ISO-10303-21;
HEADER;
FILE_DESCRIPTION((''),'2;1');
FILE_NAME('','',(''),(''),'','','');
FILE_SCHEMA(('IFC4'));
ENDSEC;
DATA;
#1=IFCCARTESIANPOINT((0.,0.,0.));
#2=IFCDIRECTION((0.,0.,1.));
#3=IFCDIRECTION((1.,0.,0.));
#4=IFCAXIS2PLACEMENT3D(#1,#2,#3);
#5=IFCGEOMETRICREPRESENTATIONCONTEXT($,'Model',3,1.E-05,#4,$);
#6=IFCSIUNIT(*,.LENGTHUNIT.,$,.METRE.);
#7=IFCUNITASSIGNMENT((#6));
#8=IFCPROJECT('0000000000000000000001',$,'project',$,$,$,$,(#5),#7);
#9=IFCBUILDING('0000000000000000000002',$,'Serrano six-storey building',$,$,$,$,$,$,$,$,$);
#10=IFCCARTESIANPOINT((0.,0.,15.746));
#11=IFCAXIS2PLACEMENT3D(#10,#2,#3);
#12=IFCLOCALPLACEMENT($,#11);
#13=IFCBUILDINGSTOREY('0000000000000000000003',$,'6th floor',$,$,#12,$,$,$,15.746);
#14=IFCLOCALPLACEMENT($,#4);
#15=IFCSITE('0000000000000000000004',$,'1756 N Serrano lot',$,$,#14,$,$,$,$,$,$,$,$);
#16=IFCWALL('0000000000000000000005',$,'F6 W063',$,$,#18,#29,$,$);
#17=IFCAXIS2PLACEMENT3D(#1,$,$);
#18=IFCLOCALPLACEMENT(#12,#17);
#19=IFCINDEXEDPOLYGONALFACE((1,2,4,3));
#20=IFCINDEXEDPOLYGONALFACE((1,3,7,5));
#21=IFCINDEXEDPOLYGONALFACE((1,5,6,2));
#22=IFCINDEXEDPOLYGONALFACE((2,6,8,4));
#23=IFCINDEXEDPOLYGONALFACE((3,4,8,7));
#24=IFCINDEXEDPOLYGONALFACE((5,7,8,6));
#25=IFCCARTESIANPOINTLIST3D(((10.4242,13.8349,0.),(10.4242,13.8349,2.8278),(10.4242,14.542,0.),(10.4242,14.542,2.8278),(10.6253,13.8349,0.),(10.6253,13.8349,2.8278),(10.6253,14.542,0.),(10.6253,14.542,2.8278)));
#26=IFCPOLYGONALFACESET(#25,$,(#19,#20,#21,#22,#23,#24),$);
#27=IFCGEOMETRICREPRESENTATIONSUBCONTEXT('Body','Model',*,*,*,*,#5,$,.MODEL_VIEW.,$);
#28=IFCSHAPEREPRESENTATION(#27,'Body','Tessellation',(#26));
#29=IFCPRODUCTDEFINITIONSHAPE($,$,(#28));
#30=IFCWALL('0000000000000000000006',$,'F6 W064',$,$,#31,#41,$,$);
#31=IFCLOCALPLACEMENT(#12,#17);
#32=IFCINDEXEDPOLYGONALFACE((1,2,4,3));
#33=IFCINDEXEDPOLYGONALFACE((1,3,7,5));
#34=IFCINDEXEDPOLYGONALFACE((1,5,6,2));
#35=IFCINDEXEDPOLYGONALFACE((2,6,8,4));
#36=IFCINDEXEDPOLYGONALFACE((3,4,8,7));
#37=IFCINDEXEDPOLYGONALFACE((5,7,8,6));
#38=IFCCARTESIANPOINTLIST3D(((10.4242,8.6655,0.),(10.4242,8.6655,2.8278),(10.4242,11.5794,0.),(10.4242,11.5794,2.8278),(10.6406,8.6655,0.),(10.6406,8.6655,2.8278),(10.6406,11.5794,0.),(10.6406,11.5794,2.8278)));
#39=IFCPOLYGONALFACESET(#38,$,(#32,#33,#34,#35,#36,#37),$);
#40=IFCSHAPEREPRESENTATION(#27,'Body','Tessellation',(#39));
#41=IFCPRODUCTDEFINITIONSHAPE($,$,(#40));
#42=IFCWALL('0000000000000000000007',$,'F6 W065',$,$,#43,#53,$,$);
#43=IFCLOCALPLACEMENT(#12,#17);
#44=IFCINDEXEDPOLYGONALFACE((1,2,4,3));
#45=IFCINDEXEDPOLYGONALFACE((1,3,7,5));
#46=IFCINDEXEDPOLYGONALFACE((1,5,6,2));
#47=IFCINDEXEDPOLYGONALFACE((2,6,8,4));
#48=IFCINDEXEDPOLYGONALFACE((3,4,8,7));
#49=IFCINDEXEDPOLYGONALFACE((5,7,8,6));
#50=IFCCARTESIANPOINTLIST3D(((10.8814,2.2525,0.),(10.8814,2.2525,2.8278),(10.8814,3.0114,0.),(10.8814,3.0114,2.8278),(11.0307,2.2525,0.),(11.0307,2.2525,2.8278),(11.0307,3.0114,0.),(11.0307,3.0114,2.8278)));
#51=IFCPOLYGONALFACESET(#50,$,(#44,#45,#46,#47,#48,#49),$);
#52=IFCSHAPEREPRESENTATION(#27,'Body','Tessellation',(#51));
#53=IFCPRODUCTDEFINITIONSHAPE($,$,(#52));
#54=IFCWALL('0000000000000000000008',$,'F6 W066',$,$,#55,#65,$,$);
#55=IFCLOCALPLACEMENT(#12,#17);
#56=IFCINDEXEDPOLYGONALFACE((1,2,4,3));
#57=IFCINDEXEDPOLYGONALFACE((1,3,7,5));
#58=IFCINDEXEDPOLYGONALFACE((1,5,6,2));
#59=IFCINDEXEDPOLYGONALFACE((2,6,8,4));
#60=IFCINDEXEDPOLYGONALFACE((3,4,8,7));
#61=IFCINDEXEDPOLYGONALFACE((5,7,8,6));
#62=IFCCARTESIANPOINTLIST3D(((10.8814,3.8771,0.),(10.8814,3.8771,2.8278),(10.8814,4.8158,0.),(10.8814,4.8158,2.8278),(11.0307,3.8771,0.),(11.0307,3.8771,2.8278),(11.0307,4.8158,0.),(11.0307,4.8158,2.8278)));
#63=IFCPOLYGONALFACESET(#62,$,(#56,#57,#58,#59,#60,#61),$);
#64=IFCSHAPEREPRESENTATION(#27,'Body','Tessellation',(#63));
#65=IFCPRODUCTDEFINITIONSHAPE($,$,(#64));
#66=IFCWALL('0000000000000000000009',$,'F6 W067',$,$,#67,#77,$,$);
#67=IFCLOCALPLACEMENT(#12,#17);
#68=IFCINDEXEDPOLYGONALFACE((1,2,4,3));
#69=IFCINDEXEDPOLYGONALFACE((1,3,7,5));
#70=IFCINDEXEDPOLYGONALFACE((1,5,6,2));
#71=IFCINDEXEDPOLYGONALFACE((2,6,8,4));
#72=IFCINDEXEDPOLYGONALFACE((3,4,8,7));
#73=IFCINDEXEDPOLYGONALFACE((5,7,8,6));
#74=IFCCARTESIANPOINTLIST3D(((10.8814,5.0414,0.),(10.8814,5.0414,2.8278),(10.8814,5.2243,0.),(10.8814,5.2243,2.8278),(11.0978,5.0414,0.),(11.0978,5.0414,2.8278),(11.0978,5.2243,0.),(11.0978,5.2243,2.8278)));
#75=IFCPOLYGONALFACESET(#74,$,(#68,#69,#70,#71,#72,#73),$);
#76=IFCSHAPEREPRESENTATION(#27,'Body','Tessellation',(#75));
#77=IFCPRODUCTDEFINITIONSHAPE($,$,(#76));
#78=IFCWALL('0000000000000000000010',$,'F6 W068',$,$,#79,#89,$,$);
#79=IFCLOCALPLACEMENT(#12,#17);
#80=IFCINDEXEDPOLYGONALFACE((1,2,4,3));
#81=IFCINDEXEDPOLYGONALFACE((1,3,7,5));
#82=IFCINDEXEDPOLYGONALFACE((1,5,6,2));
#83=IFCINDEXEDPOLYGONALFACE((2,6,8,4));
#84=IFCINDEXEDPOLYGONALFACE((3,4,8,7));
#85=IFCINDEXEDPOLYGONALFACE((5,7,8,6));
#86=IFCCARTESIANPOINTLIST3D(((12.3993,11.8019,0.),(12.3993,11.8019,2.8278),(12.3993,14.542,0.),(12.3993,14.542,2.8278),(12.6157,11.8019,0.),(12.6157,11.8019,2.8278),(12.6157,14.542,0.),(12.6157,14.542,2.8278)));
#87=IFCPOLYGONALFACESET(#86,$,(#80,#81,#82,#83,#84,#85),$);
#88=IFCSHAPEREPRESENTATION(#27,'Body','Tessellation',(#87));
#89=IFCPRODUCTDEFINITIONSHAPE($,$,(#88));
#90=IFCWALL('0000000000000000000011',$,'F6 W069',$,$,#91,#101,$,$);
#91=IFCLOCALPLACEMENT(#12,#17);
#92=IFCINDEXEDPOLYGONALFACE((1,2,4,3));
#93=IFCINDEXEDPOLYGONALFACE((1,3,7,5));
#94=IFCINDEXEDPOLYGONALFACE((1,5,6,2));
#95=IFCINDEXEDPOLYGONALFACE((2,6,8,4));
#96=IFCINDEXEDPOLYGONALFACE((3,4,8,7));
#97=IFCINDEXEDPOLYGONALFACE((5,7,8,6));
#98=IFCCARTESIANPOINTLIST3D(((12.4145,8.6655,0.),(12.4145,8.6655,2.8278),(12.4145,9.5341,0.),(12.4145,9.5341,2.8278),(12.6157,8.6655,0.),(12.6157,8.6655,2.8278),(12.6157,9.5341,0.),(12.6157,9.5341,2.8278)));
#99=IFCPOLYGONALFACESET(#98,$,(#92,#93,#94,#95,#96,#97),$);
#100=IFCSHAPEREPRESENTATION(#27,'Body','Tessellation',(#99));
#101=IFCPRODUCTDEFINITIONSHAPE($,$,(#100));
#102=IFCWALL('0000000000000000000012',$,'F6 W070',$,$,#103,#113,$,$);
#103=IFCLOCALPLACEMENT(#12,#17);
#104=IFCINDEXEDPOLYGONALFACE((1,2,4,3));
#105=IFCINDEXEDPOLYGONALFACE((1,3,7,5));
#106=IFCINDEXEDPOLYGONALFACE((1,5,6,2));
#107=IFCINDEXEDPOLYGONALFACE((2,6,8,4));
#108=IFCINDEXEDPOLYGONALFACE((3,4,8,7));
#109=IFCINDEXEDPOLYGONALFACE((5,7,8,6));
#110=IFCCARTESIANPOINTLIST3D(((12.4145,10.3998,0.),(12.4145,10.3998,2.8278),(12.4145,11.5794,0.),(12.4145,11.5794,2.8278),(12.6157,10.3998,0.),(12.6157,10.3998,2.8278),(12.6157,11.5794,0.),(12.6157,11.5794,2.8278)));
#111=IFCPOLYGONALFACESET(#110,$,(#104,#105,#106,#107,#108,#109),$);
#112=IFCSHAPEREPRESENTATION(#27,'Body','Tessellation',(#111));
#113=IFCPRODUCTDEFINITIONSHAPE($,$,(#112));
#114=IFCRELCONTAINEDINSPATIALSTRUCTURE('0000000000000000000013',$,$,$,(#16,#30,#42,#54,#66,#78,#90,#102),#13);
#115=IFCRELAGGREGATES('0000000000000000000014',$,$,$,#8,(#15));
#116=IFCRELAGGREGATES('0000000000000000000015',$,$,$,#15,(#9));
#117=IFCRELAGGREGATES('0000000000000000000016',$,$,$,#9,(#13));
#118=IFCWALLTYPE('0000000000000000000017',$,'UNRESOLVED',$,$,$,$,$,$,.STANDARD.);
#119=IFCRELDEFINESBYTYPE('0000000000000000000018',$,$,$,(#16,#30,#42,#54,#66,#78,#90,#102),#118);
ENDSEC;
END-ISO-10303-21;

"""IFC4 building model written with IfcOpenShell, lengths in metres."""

from ifc_helpers import new_model, si_unit, frame, origin_with_axes, place, context, subcontext, project, spatial, polyline, outline, extrude, type_object, element, save


model = new_model("IFC4")

# Units and contexts
model_context = context("Model", 3, precision=1e-05, world=origin_with_axes())
body_context = subcontext(model_context, "Body", "Model", "MODEL_VIEW")
ifc_project = project(units=[si_unit("LENGTHUNIT", "METRE")], contexts=[model_context])

# Site, building, storey
site_placement = place(None, origin_with_axes())
site = spatial("IfcSite", under=ifc_project, at=site_placement, Name="1756 N Serrano lot")
building = spatial("IfcBuilding", under=site, Name="Serrano six-storey building")
storey_placement = place(None, frame((0.0, 0.0, 15.746), z_axis=(0.0, 0.0, 1.0), x_axis=(1.0, 0.0, 0.0)))
storey = spatial("IfcBuildingStorey", under=building, at=storey_placement, Name="6th floor", Elevation=15.746)

# Walls
wall_type = type_object("IfcWallType", Name="UNRESOLVED", PredefinedType="STANDARD")
wall_1_placement = place(storey_placement, frame((0.0, 0.0, -15.746), z_axis=(0.0, 0.0, 1.0), x_axis=(1.0, 0.0, 0.0)))
element("IfcWall", 1, at=wall_1_placement, inside=storey, type_object=wall_type, Name="F6 W063", context=body_context, shape_type="SweptSolid", body=[
    extrude(outline(polyline([(10.4242, 14.542), (10.6253, 14.542), (10.6253, 13.8349), (10.4242, 13.8349), (10.4242, 14.542)])), frame((0.0, 0.0, 15.746)), (0.0, 0.0, 1.0), 2.8278),
])
wall_2_placement = place(storey_placement, frame((0.0, 0.0, -15.746), z_axis=(0.0, 0.0, 1.0), x_axis=(1.0, 0.0, 0.0)))
element("IfcWall", 2, at=wall_2_placement, inside=storey, type_object=wall_type, Name="F6 W064", context=body_context, shape_type="SweptSolid", body=[
    extrude(outline(polyline([(10.4242, 11.5794), (10.6406, 11.5794), (10.6406, 8.6655), (10.4242, 8.6655), (10.4242, 11.5794)])), frame((0.0, 0.0, 15.746)), (0.0, 0.0, 1.0), 2.8278),
])
wall_3_placement = place(storey_placement, frame((0.0, 0.0, -15.746), z_axis=(0.0, 0.0, 1.0), x_axis=(1.0, 0.0, 0.0)))
element("IfcWall", 3, at=wall_3_placement, inside=storey, type_object=wall_type, Name="F6 W065", context=body_context, shape_type="SweptSolid", body=[
    extrude(outline(polyline([(10.8814, 3.0114), (11.0307, 3.0114), (11.0307, 2.2525), (10.8814, 2.2525), (10.8814, 3.0114)])), frame((0.0, 0.0, 15.746)), (0.0, 0.0, 1.0), 2.8278),
])
wall_4_placement = place(storey_placement, frame((0.0, 0.0, -15.746), z_axis=(0.0, 0.0, 1.0), x_axis=(1.0, 0.0, 0.0)))
element("IfcWall", 4, at=wall_4_placement, inside=storey, type_object=wall_type, Name="F6 W066", context=body_context, shape_type="SweptSolid", body=[
    extrude(outline(polyline([(10.8814, 4.8158), (11.0307, 4.8158), (11.0307, 3.8771), (10.8814, 3.8771), (10.8814, 4.8158)])), frame((0.0, 0.0, 15.746)), (0.0, 0.0, 1.0), 2.8278),
])
wall_5_placement = place(storey_placement, frame((0.0, 0.0, -15.746), z_axis=(0.0, 0.0, 1.0), x_axis=(1.0, 0.0, 0.0)))
element("IfcWall", 5, at=wall_5_placement, inside=storey, type_object=wall_type, Name="F6 W067", context=body_context, shape_type="SweptSolid", body=[
    extrude(outline(polyline([(10.8814, 5.2243), (11.0978, 5.2243), (11.0978, 5.0414), (10.8814, 5.0414), (10.8814, 5.2243)])), frame((0.0, 0.0, 15.746)), (0.0, 0.0, 1.0), 2.8278),
])
wall_6_placement = place(storey_placement, frame((0.0, 0.0, -15.746), z_axis=(0.0, 0.0, 1.0), x_axis=(1.0, 0.0, 0.0)))
element("IfcWall", 6, at=wall_6_placement, inside=storey, type_object=wall_type, Name="F6 W068", context=body_context, shape_type="SweptSolid", body=[
    extrude(outline(polyline([(12.3993, 14.542), (12.6157, 14.542), (12.6157, 11.8019), (12.3993, 11.8019), (12.3993, 14.542)])), frame((0.0, 0.0, 15.746)), (0.0, 0.0, 1.0), 2.8278),
])
wall_7_placement = place(storey_placement, frame((0.0, 0.0, -15.746), z_axis=(0.0, 0.0, 1.0), x_axis=(1.0, 0.0, 0.0)))
element("IfcWall", 7, at=wall_7_placement, inside=storey, type_object=wall_type, Name="F6 W069", context=body_context, shape_type="SweptSolid", body=[
    extrude(outline(polyline([(12.4145, 9.5341), (12.6157, 9.5341), (12.6157, 8.6655), (12.4145, 8.6655), (12.4145, 9.5341)])), frame((0.0, 0.0, 15.746)), (0.0, 0.0, 1.0), 2.8278),
])
wall_8_placement = place(storey_placement, frame((0.0, 0.0, -15.746), z_axis=(0.0, 0.0, 1.0), x_axis=(1.0, 0.0, 0.0)))
element("IfcWall", 8, at=wall_8_placement, inside=storey, type_object=wall_type, Name="F6 W070", context=body_context, shape_type="SweptSolid", body=[
    extrude(outline(polyline([(12.4145, 11.5794), (12.6157, 11.5794), (12.6157, 10.3998), (12.4145, 10.3998), (12.4145, 11.5794)])), frame((0.0, 0.0, 15.746)), (0.0, 0.0, 1.0), 2.8278),
])

save(model, "model.ifc")
